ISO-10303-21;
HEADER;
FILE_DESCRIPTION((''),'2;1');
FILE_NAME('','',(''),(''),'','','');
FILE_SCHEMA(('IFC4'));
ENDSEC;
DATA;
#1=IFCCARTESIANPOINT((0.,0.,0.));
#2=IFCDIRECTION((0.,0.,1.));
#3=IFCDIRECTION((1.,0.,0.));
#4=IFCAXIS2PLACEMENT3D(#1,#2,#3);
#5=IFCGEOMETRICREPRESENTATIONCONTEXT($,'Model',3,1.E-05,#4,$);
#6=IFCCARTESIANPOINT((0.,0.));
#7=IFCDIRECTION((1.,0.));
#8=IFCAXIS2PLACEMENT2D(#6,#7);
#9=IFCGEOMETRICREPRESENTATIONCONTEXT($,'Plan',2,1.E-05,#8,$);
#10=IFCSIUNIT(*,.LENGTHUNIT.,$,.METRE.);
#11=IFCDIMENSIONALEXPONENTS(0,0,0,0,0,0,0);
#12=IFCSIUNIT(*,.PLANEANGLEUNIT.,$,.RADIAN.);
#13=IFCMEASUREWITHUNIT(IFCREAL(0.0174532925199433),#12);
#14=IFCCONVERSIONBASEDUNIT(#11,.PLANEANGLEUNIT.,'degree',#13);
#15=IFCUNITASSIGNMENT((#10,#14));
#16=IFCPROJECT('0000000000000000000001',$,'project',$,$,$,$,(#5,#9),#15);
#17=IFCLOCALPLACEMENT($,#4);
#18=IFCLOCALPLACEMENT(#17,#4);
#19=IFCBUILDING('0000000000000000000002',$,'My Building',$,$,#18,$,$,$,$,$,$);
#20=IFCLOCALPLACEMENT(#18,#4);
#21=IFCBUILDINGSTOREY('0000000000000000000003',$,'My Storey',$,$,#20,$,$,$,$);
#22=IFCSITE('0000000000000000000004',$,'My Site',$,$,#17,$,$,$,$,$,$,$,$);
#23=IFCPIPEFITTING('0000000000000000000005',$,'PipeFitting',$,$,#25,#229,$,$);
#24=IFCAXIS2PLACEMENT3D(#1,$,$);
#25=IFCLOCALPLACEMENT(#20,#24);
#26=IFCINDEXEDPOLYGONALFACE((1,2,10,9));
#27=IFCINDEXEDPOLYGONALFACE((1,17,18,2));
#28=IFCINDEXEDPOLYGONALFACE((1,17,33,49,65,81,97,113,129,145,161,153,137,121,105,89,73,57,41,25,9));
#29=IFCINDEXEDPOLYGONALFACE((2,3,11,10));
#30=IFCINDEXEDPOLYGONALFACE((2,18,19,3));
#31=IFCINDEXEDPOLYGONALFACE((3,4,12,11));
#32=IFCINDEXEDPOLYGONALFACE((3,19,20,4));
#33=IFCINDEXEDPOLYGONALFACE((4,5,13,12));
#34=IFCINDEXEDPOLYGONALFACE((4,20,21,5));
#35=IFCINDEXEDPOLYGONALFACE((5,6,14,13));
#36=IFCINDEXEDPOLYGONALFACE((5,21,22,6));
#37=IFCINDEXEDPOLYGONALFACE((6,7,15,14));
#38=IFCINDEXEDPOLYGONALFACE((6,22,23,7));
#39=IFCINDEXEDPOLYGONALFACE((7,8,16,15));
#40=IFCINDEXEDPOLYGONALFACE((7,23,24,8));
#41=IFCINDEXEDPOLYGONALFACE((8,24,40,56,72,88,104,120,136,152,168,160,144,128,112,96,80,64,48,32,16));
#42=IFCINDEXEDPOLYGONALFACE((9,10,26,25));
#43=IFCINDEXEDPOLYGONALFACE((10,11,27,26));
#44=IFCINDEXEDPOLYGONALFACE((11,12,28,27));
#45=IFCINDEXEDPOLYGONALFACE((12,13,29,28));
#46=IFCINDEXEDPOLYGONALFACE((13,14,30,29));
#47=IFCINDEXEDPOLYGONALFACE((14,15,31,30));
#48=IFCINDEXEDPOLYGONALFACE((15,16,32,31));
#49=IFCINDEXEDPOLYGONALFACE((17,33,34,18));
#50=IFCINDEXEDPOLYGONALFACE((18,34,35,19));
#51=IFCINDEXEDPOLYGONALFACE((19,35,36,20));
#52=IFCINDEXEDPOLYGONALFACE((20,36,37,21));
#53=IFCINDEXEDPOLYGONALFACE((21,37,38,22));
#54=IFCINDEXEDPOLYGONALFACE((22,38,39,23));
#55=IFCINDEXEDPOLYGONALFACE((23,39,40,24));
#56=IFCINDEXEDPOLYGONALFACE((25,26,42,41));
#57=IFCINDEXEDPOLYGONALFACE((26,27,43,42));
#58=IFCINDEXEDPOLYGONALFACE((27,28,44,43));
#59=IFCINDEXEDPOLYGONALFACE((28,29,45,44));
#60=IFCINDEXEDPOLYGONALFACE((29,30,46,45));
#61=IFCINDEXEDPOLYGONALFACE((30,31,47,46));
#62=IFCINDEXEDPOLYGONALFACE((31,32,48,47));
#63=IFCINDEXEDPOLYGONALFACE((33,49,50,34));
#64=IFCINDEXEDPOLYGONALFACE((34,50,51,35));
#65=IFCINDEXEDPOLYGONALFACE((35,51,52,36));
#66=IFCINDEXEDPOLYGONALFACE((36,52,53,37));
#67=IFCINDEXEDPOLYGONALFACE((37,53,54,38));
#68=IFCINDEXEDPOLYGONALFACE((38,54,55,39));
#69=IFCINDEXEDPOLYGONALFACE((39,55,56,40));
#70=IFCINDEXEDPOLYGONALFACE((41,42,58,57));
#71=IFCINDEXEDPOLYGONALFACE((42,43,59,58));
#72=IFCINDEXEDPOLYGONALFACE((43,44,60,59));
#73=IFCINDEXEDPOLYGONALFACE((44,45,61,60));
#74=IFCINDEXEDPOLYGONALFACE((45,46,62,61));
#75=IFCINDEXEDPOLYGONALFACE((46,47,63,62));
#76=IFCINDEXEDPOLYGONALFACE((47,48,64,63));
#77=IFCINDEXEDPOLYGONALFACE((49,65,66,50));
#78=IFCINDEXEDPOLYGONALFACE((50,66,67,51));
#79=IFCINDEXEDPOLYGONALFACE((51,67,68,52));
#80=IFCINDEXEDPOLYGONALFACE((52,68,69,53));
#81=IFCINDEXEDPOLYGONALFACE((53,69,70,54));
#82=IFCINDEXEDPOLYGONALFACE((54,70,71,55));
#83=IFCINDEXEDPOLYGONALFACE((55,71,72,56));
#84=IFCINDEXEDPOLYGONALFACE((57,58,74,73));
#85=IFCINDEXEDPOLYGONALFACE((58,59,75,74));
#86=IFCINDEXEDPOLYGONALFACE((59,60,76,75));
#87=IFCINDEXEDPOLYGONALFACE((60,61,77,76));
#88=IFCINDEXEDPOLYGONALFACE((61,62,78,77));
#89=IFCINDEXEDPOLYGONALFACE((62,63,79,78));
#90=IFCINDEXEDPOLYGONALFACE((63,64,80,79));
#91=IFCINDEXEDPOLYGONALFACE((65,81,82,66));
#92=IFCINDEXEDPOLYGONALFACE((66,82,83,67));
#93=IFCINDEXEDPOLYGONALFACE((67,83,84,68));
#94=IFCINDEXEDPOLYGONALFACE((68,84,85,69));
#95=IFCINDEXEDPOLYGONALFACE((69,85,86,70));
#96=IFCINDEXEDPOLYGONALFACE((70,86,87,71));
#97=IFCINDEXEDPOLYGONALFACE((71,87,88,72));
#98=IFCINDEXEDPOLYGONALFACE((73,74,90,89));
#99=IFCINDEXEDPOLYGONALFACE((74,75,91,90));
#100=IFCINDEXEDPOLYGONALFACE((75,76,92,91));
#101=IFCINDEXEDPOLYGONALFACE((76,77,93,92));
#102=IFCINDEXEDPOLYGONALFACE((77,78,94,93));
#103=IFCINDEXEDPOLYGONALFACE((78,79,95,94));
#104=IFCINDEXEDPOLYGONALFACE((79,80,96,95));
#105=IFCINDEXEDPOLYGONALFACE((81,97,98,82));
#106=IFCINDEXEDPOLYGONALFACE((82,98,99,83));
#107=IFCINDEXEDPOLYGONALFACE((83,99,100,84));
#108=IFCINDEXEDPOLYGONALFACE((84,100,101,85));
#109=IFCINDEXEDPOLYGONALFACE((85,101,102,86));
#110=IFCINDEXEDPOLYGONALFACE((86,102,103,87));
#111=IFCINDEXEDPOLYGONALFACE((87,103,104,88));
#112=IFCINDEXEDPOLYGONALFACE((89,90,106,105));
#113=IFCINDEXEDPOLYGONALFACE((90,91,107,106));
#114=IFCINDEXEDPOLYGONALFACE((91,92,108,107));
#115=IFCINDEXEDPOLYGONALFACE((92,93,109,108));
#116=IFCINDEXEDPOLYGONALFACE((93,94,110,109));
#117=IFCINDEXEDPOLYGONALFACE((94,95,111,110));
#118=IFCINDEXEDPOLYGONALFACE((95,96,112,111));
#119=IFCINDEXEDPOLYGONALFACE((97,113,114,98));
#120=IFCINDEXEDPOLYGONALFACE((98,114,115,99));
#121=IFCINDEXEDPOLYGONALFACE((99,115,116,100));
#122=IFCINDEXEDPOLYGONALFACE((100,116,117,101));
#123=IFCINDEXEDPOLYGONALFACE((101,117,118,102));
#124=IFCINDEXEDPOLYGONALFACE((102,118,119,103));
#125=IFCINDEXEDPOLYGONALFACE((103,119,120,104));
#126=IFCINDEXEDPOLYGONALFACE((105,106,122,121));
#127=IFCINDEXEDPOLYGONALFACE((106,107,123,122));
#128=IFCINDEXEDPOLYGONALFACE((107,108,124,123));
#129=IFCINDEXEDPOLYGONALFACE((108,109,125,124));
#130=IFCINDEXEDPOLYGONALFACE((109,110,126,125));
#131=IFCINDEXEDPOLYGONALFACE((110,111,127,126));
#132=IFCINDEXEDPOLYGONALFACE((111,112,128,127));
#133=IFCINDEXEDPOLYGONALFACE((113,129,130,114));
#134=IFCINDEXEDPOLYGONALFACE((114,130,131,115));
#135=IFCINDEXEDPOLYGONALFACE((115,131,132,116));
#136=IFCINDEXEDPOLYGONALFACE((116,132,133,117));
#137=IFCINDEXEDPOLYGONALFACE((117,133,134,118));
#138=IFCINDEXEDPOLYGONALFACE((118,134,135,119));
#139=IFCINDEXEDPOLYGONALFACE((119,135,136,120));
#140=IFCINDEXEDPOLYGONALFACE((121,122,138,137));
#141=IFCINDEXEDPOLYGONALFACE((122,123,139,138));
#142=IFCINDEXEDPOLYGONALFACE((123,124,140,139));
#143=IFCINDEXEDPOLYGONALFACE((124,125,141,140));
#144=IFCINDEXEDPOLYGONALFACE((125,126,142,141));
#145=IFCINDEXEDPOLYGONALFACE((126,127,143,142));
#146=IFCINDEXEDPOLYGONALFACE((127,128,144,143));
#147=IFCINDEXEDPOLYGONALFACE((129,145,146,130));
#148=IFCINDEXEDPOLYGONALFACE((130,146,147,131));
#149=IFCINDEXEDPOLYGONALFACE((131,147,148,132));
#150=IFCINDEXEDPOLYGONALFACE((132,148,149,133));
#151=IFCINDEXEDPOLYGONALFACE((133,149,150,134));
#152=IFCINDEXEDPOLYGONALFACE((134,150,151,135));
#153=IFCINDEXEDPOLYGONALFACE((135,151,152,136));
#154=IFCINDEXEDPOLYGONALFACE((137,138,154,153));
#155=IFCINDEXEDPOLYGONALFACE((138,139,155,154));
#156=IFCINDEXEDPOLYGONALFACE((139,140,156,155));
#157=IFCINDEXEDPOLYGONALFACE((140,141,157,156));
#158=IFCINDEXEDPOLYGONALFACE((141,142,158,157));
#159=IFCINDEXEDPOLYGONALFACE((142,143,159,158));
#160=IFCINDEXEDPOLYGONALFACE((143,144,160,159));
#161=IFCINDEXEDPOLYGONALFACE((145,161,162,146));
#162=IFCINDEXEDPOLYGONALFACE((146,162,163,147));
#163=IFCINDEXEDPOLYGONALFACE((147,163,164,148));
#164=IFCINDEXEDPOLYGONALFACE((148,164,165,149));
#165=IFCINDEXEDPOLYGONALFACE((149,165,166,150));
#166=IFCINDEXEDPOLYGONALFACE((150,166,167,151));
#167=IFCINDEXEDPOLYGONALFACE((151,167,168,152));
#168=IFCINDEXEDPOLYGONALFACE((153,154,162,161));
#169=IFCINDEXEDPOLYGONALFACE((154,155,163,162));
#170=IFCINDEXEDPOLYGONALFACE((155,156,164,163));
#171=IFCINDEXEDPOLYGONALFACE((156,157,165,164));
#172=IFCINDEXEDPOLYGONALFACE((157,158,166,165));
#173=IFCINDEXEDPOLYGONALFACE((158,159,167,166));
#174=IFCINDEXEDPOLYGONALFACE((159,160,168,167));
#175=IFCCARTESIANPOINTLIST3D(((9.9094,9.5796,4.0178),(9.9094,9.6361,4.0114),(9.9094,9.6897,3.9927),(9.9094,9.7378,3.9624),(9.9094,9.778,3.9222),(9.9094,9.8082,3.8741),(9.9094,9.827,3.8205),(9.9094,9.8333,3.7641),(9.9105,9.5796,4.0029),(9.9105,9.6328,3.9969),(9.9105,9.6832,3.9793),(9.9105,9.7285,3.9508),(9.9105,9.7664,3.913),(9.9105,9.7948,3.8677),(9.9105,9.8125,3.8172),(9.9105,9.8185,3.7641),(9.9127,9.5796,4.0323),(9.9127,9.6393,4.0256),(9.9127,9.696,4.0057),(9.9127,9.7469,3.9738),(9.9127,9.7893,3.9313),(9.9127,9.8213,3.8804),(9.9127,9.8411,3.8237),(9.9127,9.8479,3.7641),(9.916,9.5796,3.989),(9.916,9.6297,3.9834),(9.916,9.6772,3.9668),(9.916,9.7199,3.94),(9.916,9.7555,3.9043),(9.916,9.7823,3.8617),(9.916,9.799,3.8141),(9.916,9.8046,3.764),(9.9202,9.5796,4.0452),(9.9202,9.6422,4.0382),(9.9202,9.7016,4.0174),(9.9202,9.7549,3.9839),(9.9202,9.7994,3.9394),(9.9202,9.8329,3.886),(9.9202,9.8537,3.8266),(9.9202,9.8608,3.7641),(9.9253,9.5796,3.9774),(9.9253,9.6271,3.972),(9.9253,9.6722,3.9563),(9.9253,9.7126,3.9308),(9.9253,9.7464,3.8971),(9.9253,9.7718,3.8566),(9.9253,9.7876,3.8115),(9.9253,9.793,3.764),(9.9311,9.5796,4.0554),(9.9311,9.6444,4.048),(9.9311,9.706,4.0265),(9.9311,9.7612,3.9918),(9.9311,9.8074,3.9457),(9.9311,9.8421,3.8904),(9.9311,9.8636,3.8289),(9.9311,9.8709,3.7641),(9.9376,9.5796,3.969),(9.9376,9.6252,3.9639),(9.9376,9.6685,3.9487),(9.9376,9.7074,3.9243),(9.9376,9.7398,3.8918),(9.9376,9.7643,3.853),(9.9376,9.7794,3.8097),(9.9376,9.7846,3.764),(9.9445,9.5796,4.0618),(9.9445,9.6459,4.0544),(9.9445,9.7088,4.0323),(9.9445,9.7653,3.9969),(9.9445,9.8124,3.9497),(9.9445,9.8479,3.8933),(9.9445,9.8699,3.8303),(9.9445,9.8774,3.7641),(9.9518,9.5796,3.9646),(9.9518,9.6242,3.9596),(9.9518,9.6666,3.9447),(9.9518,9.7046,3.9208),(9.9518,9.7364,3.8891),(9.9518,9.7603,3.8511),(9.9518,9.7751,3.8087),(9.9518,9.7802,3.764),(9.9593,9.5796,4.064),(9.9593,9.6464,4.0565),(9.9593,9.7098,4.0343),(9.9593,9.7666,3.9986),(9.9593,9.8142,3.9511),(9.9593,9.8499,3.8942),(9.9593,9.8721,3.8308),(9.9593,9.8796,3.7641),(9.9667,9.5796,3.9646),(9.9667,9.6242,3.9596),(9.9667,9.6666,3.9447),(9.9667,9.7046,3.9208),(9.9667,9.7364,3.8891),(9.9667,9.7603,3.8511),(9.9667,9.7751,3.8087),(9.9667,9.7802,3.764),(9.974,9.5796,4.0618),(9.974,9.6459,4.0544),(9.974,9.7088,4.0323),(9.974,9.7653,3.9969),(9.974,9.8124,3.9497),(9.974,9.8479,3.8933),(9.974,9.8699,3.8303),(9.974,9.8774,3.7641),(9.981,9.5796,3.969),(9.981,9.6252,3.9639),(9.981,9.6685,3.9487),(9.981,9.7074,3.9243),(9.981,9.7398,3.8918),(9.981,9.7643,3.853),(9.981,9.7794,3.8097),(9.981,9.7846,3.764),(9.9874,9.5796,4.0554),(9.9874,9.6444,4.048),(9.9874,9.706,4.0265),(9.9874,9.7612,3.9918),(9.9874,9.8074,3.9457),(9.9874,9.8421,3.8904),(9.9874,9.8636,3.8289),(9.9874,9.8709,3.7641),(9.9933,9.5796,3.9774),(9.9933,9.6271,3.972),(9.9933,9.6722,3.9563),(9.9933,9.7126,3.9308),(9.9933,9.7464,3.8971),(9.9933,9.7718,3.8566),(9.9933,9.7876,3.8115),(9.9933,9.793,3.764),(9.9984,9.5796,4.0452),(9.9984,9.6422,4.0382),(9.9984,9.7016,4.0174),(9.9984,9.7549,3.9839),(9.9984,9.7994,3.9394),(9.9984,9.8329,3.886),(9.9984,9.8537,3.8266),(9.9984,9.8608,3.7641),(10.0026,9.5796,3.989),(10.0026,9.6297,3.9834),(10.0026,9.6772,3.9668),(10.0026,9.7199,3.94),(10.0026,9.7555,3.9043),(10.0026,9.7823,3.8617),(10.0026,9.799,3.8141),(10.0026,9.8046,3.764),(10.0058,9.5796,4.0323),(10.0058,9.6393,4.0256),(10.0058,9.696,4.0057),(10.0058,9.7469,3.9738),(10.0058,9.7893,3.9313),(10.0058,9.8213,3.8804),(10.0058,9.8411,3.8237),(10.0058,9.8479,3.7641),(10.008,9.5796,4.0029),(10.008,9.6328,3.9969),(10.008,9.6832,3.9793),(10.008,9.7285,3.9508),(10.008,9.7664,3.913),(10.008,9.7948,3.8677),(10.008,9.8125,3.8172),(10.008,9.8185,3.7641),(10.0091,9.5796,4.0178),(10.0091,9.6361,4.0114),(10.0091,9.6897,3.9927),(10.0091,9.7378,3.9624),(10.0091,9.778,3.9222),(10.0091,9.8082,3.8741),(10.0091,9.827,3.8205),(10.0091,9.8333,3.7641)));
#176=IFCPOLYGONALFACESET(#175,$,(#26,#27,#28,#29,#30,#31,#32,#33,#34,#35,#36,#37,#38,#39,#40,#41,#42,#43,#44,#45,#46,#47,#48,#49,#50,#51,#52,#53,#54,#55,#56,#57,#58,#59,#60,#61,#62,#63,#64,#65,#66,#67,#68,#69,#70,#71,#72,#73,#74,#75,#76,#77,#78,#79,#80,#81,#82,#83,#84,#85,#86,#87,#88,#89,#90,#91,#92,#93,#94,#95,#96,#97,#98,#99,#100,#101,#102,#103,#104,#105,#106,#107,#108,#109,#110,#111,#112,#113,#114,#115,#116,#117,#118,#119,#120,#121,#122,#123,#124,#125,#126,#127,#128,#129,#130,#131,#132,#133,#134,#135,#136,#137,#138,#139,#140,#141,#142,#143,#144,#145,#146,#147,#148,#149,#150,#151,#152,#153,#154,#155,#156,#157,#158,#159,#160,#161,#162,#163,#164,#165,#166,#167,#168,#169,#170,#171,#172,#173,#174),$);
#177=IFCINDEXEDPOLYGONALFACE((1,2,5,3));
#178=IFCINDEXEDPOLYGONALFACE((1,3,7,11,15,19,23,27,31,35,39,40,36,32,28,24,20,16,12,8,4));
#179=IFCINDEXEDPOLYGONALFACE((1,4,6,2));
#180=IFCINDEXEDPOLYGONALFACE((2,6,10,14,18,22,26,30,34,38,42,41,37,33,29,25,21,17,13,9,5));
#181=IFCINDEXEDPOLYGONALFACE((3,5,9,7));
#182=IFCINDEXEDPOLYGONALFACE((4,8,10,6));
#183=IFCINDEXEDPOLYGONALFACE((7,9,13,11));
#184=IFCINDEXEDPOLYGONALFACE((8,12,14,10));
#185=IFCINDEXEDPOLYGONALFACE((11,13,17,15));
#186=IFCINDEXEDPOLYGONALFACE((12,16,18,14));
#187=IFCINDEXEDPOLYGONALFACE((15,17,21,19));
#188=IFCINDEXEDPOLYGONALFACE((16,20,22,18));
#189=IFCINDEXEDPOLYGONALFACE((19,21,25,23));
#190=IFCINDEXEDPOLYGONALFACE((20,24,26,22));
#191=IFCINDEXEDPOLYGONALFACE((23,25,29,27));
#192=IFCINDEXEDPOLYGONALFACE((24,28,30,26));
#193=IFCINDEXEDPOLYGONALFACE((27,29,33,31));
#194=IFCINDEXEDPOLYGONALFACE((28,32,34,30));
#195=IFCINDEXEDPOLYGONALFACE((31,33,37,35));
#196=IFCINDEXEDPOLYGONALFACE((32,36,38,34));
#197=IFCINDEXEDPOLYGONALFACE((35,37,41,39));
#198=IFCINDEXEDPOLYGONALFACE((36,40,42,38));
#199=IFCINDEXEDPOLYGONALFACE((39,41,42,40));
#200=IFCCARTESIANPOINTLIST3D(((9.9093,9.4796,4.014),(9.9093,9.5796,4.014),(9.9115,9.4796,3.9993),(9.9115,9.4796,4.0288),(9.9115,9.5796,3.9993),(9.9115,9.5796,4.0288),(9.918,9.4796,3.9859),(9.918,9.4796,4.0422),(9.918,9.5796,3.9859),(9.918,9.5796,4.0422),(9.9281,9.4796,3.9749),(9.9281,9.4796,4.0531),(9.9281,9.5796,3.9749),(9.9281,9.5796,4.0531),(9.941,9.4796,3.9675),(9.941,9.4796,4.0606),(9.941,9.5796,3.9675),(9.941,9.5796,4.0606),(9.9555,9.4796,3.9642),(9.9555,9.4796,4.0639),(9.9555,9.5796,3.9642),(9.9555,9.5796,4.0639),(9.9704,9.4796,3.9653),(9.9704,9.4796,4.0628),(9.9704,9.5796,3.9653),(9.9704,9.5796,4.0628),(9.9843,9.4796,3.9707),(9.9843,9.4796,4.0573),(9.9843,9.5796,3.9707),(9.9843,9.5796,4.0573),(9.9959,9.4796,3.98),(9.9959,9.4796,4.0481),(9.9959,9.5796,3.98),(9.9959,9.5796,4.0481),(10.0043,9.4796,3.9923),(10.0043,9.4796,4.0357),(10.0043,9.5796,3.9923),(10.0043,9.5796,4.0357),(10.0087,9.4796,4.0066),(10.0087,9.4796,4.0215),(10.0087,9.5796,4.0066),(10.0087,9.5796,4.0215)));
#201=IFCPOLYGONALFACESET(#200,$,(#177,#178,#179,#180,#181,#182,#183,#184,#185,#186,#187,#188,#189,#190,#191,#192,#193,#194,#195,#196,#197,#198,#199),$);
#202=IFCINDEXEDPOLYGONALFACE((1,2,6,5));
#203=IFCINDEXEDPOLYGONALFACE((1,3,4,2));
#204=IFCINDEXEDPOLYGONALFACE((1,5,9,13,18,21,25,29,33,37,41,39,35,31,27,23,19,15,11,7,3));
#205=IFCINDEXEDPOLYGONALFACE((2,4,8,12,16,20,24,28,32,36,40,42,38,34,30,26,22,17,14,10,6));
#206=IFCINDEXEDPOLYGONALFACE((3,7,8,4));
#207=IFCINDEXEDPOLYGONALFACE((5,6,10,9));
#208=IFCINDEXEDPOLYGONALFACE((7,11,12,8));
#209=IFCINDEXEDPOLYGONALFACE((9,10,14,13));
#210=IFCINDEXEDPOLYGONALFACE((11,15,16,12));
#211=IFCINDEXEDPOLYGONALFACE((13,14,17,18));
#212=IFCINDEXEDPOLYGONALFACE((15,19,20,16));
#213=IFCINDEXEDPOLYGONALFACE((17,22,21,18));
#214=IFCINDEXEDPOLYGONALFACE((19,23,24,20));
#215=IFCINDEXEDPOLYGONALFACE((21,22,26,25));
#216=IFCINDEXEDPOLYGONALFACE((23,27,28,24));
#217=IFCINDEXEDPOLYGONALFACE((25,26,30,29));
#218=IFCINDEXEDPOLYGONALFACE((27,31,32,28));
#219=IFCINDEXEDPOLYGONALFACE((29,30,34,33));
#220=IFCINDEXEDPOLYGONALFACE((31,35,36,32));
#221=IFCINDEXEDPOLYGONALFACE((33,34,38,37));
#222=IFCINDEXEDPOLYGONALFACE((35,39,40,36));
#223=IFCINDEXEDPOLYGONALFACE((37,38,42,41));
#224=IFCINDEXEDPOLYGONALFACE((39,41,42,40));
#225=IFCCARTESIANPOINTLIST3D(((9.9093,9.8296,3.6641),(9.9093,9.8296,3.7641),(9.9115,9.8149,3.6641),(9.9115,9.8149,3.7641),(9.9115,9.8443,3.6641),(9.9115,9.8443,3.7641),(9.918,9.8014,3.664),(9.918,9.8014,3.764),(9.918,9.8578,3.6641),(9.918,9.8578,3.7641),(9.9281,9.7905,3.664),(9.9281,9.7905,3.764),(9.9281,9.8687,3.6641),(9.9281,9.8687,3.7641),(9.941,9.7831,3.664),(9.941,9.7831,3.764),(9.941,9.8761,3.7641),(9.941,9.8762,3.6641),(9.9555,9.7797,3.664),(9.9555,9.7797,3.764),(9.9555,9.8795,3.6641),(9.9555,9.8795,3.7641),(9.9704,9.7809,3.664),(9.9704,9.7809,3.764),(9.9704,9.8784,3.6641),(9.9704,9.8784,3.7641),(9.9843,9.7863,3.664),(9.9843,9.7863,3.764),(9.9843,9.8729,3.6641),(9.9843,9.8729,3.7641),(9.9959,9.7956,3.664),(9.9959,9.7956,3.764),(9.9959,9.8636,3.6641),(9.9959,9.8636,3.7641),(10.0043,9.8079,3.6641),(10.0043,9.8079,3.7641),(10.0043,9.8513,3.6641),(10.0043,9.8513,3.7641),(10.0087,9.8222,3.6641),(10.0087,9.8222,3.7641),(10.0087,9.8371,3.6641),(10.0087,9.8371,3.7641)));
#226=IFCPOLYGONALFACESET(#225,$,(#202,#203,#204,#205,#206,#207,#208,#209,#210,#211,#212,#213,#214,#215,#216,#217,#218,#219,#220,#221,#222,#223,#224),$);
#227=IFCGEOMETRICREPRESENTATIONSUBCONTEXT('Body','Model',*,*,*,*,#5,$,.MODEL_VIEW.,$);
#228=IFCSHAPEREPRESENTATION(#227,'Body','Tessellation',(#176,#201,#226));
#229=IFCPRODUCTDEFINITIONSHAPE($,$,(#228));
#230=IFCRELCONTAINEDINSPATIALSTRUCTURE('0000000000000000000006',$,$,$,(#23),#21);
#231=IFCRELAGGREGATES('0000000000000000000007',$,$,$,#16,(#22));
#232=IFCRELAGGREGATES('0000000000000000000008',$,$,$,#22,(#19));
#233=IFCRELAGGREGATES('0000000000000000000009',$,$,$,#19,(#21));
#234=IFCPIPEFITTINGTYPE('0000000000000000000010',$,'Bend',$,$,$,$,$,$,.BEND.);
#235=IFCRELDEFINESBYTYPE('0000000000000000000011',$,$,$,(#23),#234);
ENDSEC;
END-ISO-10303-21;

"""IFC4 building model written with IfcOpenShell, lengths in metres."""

from ifc_helpers import new_model, entity, si_unit, converted_unit, frame, origin_with_axes, origin_2d_with_axis, place, context, subcontext, project, spatial, circle, extrude, source, transform, mapped, type_object, type_shapes, element, save


model = new_model("IFC4")

# Units and contexts
model_context = context("Model", 3, precision=1e-05, world=origin_with_axes())
plan_context = context("Plan", 2, precision=1e-05, world=origin_2d_with_axis())
body_context_1 = subcontext(model_context, "Body", "Model", "MODEL_VIEW")
ifc_project = project(units=[si_unit("LENGTHUNIT", "METRE"), converted_unit("PLANEANGLEUNIT", "degree", entity("IfcReal", 0.0174532925199433), si_unit("PLANEANGLEUNIT", "RADIAN"), dimensions=[0, 0, 0, 0, 0, 0, 0])], contexts=[model_context, plan_context])

# Site, building, storey
site_placement = place(None, origin_with_axes())
site = spatial("IfcSite", under=ifc_project, at=site_placement, Name="My Site")
building_placement = place(site_placement, origin_with_axes())
building = spatial("IfcBuilding", under=site, at=building_placement, Name="My Building")
storey_placement = place(building_placement, origin_with_axes())
storey = spatial("IfcBuildingStorey", under=building, at=storey_placement, Name="My Storey")

# Pipe fitting
pipe_fitting_type_1 = type_object("IfcPipeFittingType", Name="Bend", PredefinedType="BEND")
shared_shape_1 = source(origin_with_axes(), body_context_1, "Body", "SolidModel", [
    entity("IfcSweptDiskSolid", entity("IfcIndexedPolyCurve", entity("IfcCartesianPointList3D", [[0.0, 0.0, 0.1], [0.0, -0.0732, 0.2768], [0.0, -0.25, 0.35]]), [entity("IfcArcIndex", [1, 2, 3])]), 0.05),
    extrude(circle(Radius=0.05), origin_with_axes(), (0.0, 0.0, 1.0), 0.1),
    extrude(circle(Radius=0.05), frame((0.0, -0.25, 0.35), z_axis=(0.0, -1.0, 0.000038), x_axis=(1.0, 0.0, 0.0)), (0.0, 0.0, 1.0), 0.1),
])
type_shapes(pipe_fitting_type_1, [shared_shape_1])
for number, where, z_axis, x_axis, name in (
    (1, (9.9593, 9.4796, 4.014), (0.0, 1.0, 0.0), (-1.0, 0.0, 0.0), "PipeFitting"),
):
    element("IfcPipeFitting", number, at=place(storey_placement, frame(where, z_axis=z_axis, x_axis=x_axis)), inside=storey, type_object=pipe_fitting_type_1, Name=name, context=body_context_1, shape_type="MappedRepresentation", body=[
        mapped(shared_shape_1, transform((0.0, 0.0, 0.0), x_axis=(1.0, 0.0, 0.0), y_axis=(0.0, 1.0, 0.0), z_axis=(0.0, 0.0, 1.0), scale=1.0)),
    ])

save(model, "model.ifc")
